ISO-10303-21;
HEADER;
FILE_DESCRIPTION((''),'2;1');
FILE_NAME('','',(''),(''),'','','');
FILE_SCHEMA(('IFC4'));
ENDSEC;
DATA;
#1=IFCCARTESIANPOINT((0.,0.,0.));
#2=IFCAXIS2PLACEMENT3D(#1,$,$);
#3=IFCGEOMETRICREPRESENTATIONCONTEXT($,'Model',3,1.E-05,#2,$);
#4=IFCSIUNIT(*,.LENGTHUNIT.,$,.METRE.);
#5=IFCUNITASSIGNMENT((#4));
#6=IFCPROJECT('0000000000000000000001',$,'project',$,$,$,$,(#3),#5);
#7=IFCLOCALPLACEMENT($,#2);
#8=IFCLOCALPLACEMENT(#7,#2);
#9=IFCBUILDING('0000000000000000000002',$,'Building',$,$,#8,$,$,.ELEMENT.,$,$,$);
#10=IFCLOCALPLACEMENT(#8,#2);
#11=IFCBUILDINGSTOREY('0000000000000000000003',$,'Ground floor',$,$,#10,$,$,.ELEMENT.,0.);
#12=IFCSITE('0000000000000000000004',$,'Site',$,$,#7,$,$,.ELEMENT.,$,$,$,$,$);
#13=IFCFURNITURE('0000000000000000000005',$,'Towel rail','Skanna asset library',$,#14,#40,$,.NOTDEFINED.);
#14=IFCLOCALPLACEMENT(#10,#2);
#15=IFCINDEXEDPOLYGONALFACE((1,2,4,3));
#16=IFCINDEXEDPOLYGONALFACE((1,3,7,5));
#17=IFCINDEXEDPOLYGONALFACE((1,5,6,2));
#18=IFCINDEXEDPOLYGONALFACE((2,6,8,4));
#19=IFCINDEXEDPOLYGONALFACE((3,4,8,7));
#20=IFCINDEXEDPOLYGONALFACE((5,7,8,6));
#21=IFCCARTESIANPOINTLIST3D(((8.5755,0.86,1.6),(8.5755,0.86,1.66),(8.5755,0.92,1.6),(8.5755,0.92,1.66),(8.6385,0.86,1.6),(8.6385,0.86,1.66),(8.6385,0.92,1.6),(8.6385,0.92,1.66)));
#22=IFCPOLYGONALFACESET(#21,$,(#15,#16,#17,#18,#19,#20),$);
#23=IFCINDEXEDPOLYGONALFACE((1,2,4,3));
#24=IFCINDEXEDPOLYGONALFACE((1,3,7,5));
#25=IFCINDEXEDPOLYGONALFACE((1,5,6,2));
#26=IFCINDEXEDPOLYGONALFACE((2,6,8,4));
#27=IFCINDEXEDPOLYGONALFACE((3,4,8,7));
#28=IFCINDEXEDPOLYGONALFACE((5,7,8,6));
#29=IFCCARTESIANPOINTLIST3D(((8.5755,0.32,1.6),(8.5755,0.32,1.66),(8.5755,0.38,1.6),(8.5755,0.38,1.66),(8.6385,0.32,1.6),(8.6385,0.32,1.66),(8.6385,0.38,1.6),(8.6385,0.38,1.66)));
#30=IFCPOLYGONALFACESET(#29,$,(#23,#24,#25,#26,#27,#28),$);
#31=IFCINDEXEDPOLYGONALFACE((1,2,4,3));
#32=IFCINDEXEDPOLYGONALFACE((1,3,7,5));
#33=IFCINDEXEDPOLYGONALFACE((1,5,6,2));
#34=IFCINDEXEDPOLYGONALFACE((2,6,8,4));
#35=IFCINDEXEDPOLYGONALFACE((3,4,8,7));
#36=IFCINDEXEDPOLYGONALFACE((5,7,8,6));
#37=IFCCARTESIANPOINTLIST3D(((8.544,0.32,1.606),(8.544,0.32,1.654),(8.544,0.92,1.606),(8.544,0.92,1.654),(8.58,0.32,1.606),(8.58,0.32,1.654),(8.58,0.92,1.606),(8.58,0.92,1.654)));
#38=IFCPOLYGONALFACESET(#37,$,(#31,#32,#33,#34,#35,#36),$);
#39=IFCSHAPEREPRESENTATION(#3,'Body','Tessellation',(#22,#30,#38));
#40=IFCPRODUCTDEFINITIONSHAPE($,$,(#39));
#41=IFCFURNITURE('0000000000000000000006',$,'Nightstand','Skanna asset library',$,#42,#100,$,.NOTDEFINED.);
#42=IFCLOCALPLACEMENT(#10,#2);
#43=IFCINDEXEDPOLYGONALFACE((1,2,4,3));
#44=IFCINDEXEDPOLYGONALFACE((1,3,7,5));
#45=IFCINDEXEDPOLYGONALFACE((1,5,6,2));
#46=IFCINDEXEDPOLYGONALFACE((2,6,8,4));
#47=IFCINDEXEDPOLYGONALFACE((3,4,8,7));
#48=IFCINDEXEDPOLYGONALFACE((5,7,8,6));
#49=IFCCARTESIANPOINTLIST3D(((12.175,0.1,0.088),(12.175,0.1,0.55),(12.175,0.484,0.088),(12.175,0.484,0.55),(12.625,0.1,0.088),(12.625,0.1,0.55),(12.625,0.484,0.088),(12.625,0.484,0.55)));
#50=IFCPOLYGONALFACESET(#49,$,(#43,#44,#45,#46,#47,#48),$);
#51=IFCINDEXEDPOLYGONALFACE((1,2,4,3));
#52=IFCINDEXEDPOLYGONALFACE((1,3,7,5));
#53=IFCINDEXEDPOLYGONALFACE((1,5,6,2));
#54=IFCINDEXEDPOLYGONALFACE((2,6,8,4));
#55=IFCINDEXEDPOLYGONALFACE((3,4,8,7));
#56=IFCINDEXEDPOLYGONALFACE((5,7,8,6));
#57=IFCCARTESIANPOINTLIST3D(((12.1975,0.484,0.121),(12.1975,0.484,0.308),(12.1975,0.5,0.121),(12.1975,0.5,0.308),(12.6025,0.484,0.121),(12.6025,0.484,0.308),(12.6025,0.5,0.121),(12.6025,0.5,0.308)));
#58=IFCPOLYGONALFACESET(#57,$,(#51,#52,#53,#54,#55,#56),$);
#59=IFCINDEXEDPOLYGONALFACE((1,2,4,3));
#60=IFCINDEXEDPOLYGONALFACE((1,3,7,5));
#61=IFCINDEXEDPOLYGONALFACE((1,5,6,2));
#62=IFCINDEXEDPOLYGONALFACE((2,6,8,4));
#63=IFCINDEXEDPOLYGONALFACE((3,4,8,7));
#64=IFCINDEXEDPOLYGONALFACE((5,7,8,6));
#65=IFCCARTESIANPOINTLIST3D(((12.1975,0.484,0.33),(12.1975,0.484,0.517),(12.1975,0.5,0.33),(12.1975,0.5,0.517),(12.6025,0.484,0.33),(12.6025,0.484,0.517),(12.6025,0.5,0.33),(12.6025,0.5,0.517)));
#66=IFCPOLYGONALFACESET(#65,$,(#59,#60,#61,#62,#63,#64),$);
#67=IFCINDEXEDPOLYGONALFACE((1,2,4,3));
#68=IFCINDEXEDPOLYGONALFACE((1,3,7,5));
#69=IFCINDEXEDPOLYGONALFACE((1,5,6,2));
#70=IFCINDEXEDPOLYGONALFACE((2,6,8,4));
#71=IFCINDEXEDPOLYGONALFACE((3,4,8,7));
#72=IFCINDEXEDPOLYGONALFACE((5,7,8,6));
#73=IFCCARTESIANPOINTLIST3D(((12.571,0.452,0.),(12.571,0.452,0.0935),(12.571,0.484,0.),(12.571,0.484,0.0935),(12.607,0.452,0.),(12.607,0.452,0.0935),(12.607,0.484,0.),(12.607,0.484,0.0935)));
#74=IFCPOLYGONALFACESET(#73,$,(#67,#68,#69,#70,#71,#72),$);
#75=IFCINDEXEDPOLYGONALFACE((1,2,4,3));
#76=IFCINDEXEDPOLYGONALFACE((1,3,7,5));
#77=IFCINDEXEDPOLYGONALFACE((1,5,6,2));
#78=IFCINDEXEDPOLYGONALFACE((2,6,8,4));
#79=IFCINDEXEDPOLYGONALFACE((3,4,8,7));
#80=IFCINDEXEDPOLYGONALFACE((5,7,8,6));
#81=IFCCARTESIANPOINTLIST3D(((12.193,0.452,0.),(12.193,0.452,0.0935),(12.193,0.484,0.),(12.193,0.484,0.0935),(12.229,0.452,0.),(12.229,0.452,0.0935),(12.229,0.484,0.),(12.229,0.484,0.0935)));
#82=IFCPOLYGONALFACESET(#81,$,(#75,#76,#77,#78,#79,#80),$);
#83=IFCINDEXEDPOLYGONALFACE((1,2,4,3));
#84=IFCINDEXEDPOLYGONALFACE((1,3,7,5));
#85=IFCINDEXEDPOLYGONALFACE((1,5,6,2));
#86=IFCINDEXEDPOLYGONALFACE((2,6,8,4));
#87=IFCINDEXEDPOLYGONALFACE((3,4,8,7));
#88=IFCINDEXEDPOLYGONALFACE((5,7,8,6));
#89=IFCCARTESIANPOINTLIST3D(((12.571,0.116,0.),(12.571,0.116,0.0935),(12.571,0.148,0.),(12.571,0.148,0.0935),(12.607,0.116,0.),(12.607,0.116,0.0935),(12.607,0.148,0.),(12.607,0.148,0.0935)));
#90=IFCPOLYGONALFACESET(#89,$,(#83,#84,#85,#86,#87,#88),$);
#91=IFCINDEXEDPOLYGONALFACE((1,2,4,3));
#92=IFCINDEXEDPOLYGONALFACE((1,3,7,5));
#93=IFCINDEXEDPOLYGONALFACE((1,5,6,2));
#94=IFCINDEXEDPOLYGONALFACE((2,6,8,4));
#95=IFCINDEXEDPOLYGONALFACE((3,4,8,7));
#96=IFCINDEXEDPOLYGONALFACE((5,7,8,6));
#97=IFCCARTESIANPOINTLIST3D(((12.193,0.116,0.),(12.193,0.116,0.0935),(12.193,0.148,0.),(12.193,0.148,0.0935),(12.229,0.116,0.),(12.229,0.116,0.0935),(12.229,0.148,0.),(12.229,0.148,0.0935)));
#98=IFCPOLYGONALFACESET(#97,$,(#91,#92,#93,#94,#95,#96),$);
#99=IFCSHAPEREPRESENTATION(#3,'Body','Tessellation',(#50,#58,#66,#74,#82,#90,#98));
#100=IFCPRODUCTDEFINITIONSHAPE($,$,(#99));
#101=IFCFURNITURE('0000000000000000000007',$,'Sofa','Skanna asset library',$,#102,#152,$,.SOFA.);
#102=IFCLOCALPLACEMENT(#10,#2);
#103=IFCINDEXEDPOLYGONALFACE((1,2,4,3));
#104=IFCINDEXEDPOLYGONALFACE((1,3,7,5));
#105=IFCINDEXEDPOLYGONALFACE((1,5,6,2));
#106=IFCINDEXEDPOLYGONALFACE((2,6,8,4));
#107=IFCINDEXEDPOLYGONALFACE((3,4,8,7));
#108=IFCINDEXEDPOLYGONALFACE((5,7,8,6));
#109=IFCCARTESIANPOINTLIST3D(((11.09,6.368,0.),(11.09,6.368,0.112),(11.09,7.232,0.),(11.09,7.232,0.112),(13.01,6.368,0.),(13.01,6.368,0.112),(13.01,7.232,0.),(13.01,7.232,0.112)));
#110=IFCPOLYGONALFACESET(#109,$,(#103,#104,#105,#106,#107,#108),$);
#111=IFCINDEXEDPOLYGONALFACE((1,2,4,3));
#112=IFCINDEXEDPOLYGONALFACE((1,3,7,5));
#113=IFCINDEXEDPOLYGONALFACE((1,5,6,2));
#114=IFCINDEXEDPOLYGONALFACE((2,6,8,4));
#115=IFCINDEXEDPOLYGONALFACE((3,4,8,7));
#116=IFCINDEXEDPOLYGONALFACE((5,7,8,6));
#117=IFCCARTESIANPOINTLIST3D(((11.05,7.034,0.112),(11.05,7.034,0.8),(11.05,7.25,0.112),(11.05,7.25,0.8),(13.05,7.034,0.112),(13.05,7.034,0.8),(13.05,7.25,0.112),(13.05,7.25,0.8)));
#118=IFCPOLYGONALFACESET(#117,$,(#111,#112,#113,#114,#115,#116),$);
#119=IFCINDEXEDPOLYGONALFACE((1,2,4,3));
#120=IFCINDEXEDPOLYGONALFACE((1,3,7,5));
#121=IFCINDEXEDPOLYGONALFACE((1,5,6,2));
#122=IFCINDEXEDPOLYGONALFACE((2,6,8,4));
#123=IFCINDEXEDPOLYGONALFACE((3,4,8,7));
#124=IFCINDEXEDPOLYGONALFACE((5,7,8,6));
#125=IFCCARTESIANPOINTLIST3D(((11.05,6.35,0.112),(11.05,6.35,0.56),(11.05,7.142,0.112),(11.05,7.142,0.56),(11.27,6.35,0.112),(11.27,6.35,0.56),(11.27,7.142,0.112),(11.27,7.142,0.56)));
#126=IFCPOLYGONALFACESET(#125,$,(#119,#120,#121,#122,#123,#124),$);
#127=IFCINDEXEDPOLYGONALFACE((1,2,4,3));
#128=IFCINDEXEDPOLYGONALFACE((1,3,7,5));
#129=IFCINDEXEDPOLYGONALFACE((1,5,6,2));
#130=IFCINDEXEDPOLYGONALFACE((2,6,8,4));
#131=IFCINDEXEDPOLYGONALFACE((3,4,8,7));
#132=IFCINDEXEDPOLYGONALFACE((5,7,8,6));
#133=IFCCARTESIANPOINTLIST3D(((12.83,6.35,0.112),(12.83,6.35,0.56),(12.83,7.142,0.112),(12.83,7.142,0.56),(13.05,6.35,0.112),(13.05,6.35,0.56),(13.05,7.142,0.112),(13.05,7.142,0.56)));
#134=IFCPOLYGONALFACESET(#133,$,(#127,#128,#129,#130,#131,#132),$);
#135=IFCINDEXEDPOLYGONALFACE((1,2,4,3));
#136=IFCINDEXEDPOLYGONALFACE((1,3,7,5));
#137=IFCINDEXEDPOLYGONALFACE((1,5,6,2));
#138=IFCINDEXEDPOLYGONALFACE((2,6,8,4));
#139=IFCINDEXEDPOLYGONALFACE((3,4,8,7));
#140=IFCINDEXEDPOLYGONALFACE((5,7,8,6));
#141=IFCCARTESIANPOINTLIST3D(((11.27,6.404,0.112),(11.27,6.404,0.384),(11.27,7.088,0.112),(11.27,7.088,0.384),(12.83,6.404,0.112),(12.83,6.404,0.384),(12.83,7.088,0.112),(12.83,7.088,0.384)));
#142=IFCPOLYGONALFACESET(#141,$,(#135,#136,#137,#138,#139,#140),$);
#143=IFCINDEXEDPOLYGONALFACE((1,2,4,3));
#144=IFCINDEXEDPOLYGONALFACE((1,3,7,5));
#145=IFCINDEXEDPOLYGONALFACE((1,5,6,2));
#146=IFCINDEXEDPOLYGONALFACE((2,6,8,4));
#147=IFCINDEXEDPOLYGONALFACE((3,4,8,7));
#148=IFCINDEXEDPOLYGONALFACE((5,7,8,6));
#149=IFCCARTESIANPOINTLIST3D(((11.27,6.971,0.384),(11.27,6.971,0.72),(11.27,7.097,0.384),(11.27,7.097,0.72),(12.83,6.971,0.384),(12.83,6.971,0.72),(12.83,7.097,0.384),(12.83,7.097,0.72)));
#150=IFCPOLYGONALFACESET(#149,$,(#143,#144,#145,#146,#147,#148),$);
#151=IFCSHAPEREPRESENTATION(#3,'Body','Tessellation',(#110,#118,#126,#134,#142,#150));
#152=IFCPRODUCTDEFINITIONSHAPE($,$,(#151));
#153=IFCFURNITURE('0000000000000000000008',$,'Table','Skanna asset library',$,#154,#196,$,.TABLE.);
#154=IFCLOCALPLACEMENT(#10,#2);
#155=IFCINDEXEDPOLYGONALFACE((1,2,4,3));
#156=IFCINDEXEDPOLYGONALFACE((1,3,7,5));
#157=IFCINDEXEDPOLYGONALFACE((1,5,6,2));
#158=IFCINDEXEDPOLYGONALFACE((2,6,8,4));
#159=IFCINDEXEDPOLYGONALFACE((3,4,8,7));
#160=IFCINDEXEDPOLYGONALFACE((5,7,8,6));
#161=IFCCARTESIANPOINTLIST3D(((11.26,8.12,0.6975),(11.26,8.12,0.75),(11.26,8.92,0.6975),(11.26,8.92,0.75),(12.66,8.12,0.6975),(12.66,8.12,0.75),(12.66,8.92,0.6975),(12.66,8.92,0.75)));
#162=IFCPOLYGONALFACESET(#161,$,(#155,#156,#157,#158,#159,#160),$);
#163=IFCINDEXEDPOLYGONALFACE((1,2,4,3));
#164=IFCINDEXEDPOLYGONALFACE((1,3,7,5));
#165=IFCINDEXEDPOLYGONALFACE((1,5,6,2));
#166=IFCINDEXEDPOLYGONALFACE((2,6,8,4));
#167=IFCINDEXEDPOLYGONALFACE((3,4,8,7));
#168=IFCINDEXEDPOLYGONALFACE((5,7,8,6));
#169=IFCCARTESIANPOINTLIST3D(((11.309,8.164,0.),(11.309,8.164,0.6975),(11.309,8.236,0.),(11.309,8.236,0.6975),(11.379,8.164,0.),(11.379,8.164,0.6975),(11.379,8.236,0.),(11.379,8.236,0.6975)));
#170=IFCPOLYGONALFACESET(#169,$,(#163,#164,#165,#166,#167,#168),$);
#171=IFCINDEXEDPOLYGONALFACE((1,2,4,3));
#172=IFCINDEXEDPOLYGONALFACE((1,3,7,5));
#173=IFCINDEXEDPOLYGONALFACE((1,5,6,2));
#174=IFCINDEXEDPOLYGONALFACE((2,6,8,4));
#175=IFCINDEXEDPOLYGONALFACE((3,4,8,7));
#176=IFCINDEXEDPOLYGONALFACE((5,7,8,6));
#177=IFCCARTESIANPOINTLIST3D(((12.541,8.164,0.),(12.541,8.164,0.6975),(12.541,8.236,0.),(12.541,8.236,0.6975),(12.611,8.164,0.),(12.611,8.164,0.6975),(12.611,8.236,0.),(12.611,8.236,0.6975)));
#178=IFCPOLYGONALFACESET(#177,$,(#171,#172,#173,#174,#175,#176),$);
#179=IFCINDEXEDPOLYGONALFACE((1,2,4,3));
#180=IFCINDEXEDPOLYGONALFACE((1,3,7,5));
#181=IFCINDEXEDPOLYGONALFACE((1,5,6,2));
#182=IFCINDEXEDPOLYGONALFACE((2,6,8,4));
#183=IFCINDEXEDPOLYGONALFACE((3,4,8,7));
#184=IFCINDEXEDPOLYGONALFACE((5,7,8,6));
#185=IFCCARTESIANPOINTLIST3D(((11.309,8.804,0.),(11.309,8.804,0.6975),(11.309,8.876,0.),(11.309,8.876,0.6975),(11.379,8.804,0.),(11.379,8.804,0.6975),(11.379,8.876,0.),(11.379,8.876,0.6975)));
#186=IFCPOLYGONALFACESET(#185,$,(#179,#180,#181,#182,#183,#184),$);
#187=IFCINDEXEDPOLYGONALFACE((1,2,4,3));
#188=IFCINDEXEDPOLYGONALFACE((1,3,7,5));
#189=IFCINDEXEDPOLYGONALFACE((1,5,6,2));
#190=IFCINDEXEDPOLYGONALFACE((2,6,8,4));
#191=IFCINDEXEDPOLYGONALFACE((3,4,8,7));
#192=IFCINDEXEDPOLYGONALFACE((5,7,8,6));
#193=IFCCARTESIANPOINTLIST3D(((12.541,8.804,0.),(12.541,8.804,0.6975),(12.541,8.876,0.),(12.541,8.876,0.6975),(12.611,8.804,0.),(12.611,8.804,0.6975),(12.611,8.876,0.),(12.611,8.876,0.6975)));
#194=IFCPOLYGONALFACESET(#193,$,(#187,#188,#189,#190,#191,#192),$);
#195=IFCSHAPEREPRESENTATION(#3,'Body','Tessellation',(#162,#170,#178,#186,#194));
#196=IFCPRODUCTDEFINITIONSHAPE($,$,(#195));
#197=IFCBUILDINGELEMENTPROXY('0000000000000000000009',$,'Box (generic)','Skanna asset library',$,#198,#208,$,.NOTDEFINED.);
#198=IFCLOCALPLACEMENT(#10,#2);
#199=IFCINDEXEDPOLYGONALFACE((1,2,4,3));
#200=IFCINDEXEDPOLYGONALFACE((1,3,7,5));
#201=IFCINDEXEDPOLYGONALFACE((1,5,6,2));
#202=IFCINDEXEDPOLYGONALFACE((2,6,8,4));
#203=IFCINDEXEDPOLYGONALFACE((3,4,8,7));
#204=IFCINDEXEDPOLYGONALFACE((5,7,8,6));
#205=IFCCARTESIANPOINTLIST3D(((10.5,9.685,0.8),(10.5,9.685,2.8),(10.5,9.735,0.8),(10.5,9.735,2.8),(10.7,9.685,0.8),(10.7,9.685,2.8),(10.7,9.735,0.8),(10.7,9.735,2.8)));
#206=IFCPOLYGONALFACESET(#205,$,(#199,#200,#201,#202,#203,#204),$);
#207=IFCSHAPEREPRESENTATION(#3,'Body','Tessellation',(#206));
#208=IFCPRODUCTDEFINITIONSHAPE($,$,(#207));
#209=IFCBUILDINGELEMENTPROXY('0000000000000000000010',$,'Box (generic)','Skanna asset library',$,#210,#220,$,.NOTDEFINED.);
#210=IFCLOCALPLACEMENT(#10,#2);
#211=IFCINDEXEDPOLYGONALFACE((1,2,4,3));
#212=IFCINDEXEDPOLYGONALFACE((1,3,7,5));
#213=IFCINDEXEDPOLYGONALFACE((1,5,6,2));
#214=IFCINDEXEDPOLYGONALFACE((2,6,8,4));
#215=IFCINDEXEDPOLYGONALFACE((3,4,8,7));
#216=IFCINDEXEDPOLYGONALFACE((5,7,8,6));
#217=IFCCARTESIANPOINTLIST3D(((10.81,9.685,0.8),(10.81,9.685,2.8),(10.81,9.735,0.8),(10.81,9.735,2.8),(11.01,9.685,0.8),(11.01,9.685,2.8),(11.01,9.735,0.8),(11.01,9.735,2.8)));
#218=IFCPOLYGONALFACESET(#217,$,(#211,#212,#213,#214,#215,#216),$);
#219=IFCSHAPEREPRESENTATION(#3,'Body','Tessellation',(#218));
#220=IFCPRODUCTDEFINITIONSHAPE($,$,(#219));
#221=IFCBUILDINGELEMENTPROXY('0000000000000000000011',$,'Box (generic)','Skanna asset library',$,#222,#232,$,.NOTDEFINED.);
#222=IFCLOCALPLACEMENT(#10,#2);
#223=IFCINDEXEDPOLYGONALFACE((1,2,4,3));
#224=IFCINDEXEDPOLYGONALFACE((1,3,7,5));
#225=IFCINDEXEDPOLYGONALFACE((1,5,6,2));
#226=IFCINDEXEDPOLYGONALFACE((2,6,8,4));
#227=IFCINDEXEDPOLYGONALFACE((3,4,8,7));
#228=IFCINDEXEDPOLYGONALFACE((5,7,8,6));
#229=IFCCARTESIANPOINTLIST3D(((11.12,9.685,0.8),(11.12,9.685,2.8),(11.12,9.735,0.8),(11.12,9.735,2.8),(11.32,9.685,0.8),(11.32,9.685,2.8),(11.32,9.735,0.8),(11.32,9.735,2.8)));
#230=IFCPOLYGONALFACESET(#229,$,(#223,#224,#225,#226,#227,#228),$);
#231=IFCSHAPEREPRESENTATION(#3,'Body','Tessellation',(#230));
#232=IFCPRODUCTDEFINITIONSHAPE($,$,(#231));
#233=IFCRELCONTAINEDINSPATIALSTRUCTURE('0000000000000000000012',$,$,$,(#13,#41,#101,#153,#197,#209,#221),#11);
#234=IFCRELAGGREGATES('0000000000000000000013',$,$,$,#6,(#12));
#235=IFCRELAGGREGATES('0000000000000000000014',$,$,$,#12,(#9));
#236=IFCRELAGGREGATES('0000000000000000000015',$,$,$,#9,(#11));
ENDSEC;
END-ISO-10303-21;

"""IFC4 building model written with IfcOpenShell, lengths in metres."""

from ifc_helpers import new_model, si_unit, frame, frame_2d, origin, origin_2d, place, context, project, spatial, rectangle, extrude, element, save


model = new_model("IFC4")

# Units and contexts
model_context = context("Model", 3, precision=1e-05, world=origin())
ifc_project = project(units=[si_unit("LENGTHUNIT", "METRE")], contexts=[model_context])

# Site, building, storey
site_placement = place(None, origin())
site = spatial("IfcSite", under=ifc_project, at=site_placement, Name="Site", CompositionType="ELEMENT")
building_placement = place(site_placement, origin())
building = spatial("IfcBuilding", under=site, at=building_placement, Name="Building", CompositionType="ELEMENT")
storey_placement = place(building_placement, origin())
storey = spatial("IfcBuildingStorey", under=building, at=storey_placement, Name="Ground floor", CompositionType="ELEMENT", Elevation=0.0)

# Furniture
furniture_1_placement = place(storey_placement, frame((8.58, 0.62, 1.6), z_axis=(0.0, 0.0, 1.0), x_axis=(0.0, -1.0, 0.0)))
element("IfcFurniture", 1, at=furniture_1_placement, inside=storey, Name="Towel rail", Description="Skanna asset library", PredefinedType="NOTDEFINED", context=model_context, shape_type="SweptSolid", body=[
    extrude(rectangle(XDim=0.06, YDim=0.063, at=frame_2d((-0.27, 0.027))), origin(), (0.0, 0.0, 1.0), 0.06),
    extrude(rectangle(XDim=0.06, YDim=0.063, at=frame_2d((0.27, 0.027))), origin(), (0.0, 0.0, 1.0), 0.06),
    extrude(rectangle(XDim=0.6, YDim=0.036, at=frame_2d((0.0, -0.018))), frame((0.0, 0.0, 0.006)), (0.0, 0.0, 1.0), 0.048),
])
furniture_2_placement = place(storey_placement, frame((12.4, 0.3, 0.0), z_axis=(0.0, 0.0, 1.0), x_axis=(-1.0, 0.0, 0.0)))
element("IfcFurniture", 2, at=furniture_2_placement, inside=storey, Name="Nightstand", Description="Skanna asset library", PredefinedType="NOTDEFINED", context=model_context, shape_type="SweptSolid", body=[
    extrude(rectangle(XDim=0.45, YDim=0.384, at=frame_2d((0.0, 0.008))), frame((0.0, 0.0, 0.088)), (0.0, 0.0, 1.0), 0.462),
    extrude(rectangle(XDim=0.405, YDim=0.016, at=frame_2d((0.0, -0.192))), frame((0.0, 0.0, 0.121)), (0.0, 0.0, 1.0), 0.187),
    extrude(rectangle(XDim=0.405, YDim=0.016, at=frame_2d((0.0, -0.192))), frame((0.0, 0.0, 0.33)), (0.0, 0.0, 1.0), 0.187),
    extrude(rectangle(XDim=0.036, YDim=0.032, at=frame_2d((-0.189, -0.168))), origin(), (0.0, 0.0, 1.0), 0.0935),
    extrude(rectangle(XDim=0.036, YDim=0.032, at=frame_2d((0.189, -0.168))), origin(), (0.0, 0.0, 1.0), 0.0935),
    extrude(rectangle(XDim=0.036, YDim=0.032, at=frame_2d((-0.189, 0.168))), origin(), (0.0, 0.0, 1.0), 0.0935),
    extrude(rectangle(XDim=0.036, YDim=0.032, at=frame_2d((0.189, 0.168))), origin(), (0.0, 0.0, 1.0), 0.0935),
])
furniture_3_placement = place(storey_placement, frame((12.05, 6.8, 0.0), z_axis=(0.0, 0.0, 1.0), x_axis=(1.0, 0.0, 0.0)))
element("IfcFurniture", 3, at=furniture_3_placement, inside=storey, Name="Sofa", Description="Skanna asset library", PredefinedType="SOFA", context=model_context, shape_type="SweptSolid", body=[
    extrude(rectangle(XDim=1.92, YDim=0.864, at=origin_2d()), origin(), (0.0, 0.0, 1.0), 0.112),
    extrude(rectangle(XDim=2.0, YDim=0.216, at=frame_2d((0.0, 0.342))), frame((0.0, 0.0, 0.112)), (0.0, 0.0, 1.0), 0.688),
    extrude(rectangle(XDim=0.22, YDim=0.792, at=frame_2d((-0.89, -0.054))), frame((0.0, 0.0, 0.112)), (0.0, 0.0, 1.0), 0.448),
    extrude(rectangle(XDim=0.22, YDim=0.792, at=frame_2d((0.89, -0.054))), frame((0.0, 0.0, 0.112)), (0.0, 0.0, 1.0), 0.448),
    extrude(rectangle(XDim=1.56, YDim=0.684, at=frame_2d((0.0, -0.054))), frame((0.0, 0.0, 0.112)), (0.0, 0.0, 1.0), 0.272),
    extrude(rectangle(XDim=1.56, YDim=0.126, at=frame_2d((0.0, 0.234))), frame((0.0, 0.0, 0.384)), (0.0, 0.0, 1.0), 0.336),
])
furniture_4_placement = place(storey_placement, frame((11.96, 8.52, 0.0), z_axis=(0.0, 0.0, 1.0), x_axis=(1.0, 0.0, 0.0)))
element("IfcFurniture", 4, at=furniture_4_placement, inside=storey, Name="Table", Description="Skanna asset library", PredefinedType="TABLE", context=model_context, shape_type="SweptSolid", body=[
    extrude(rectangle(XDim=1.4, YDim=0.8, at=origin_2d()), frame((0.0, 0.0, 0.6975)), (0.0, 0.0, 1.0), 0.0525),
    extrude(rectangle(XDim=0.07, YDim=0.072, at=frame_2d((-0.616, -0.32))), origin(), (0.0, 0.0, 1.0), 0.6975),
    extrude(rectangle(XDim=0.07, YDim=0.072, at=frame_2d((0.616, -0.32))), origin(), (0.0, 0.0, 1.0), 0.6975),
    extrude(rectangle(XDim=0.07, YDim=0.072, at=frame_2d((-0.616, 0.32))), origin(), (0.0, 0.0, 1.0), 0.6975),
    extrude(rectangle(XDim=0.07, YDim=0.072, at=frame_2d((0.616, 0.32))), origin(), (0.0, 0.0, 1.0), 0.6975),
])

# Building element proxies
for number, where, z_axis, x_axis, name in (
    (5, (10.6, 9.71, 0.8), (0.0, 0.0, 1.0), (1.0, 0.0, 0.0), "Box (generic)"),
    (6, (10.91, 9.71, 0.8), (0.0, 0.0, 1.0), (1.0, 0.0, 0.0), "Box (generic)"),
    (7, (11.22, 9.71, 0.8), (0.0, 0.0, 1.0), (1.0, 0.0, 0.0), "Box (generic)"),
):
    element("IfcBuildingElementProxy", number, at=place(storey_placement, frame(where, z_axis=z_axis, x_axis=x_axis)), inside=storey, Name=name, Description="Skanna asset library", PredefinedType="NOTDEFINED", context=model_context, shape_type="SweptSolid", body=[
        extrude(rectangle(XDim=0.2, YDim=0.05, at=origin_2d()), origin(), (0.0, 0.0, 1.0), 2.0),
    ])

save(model, "model.ifc")
